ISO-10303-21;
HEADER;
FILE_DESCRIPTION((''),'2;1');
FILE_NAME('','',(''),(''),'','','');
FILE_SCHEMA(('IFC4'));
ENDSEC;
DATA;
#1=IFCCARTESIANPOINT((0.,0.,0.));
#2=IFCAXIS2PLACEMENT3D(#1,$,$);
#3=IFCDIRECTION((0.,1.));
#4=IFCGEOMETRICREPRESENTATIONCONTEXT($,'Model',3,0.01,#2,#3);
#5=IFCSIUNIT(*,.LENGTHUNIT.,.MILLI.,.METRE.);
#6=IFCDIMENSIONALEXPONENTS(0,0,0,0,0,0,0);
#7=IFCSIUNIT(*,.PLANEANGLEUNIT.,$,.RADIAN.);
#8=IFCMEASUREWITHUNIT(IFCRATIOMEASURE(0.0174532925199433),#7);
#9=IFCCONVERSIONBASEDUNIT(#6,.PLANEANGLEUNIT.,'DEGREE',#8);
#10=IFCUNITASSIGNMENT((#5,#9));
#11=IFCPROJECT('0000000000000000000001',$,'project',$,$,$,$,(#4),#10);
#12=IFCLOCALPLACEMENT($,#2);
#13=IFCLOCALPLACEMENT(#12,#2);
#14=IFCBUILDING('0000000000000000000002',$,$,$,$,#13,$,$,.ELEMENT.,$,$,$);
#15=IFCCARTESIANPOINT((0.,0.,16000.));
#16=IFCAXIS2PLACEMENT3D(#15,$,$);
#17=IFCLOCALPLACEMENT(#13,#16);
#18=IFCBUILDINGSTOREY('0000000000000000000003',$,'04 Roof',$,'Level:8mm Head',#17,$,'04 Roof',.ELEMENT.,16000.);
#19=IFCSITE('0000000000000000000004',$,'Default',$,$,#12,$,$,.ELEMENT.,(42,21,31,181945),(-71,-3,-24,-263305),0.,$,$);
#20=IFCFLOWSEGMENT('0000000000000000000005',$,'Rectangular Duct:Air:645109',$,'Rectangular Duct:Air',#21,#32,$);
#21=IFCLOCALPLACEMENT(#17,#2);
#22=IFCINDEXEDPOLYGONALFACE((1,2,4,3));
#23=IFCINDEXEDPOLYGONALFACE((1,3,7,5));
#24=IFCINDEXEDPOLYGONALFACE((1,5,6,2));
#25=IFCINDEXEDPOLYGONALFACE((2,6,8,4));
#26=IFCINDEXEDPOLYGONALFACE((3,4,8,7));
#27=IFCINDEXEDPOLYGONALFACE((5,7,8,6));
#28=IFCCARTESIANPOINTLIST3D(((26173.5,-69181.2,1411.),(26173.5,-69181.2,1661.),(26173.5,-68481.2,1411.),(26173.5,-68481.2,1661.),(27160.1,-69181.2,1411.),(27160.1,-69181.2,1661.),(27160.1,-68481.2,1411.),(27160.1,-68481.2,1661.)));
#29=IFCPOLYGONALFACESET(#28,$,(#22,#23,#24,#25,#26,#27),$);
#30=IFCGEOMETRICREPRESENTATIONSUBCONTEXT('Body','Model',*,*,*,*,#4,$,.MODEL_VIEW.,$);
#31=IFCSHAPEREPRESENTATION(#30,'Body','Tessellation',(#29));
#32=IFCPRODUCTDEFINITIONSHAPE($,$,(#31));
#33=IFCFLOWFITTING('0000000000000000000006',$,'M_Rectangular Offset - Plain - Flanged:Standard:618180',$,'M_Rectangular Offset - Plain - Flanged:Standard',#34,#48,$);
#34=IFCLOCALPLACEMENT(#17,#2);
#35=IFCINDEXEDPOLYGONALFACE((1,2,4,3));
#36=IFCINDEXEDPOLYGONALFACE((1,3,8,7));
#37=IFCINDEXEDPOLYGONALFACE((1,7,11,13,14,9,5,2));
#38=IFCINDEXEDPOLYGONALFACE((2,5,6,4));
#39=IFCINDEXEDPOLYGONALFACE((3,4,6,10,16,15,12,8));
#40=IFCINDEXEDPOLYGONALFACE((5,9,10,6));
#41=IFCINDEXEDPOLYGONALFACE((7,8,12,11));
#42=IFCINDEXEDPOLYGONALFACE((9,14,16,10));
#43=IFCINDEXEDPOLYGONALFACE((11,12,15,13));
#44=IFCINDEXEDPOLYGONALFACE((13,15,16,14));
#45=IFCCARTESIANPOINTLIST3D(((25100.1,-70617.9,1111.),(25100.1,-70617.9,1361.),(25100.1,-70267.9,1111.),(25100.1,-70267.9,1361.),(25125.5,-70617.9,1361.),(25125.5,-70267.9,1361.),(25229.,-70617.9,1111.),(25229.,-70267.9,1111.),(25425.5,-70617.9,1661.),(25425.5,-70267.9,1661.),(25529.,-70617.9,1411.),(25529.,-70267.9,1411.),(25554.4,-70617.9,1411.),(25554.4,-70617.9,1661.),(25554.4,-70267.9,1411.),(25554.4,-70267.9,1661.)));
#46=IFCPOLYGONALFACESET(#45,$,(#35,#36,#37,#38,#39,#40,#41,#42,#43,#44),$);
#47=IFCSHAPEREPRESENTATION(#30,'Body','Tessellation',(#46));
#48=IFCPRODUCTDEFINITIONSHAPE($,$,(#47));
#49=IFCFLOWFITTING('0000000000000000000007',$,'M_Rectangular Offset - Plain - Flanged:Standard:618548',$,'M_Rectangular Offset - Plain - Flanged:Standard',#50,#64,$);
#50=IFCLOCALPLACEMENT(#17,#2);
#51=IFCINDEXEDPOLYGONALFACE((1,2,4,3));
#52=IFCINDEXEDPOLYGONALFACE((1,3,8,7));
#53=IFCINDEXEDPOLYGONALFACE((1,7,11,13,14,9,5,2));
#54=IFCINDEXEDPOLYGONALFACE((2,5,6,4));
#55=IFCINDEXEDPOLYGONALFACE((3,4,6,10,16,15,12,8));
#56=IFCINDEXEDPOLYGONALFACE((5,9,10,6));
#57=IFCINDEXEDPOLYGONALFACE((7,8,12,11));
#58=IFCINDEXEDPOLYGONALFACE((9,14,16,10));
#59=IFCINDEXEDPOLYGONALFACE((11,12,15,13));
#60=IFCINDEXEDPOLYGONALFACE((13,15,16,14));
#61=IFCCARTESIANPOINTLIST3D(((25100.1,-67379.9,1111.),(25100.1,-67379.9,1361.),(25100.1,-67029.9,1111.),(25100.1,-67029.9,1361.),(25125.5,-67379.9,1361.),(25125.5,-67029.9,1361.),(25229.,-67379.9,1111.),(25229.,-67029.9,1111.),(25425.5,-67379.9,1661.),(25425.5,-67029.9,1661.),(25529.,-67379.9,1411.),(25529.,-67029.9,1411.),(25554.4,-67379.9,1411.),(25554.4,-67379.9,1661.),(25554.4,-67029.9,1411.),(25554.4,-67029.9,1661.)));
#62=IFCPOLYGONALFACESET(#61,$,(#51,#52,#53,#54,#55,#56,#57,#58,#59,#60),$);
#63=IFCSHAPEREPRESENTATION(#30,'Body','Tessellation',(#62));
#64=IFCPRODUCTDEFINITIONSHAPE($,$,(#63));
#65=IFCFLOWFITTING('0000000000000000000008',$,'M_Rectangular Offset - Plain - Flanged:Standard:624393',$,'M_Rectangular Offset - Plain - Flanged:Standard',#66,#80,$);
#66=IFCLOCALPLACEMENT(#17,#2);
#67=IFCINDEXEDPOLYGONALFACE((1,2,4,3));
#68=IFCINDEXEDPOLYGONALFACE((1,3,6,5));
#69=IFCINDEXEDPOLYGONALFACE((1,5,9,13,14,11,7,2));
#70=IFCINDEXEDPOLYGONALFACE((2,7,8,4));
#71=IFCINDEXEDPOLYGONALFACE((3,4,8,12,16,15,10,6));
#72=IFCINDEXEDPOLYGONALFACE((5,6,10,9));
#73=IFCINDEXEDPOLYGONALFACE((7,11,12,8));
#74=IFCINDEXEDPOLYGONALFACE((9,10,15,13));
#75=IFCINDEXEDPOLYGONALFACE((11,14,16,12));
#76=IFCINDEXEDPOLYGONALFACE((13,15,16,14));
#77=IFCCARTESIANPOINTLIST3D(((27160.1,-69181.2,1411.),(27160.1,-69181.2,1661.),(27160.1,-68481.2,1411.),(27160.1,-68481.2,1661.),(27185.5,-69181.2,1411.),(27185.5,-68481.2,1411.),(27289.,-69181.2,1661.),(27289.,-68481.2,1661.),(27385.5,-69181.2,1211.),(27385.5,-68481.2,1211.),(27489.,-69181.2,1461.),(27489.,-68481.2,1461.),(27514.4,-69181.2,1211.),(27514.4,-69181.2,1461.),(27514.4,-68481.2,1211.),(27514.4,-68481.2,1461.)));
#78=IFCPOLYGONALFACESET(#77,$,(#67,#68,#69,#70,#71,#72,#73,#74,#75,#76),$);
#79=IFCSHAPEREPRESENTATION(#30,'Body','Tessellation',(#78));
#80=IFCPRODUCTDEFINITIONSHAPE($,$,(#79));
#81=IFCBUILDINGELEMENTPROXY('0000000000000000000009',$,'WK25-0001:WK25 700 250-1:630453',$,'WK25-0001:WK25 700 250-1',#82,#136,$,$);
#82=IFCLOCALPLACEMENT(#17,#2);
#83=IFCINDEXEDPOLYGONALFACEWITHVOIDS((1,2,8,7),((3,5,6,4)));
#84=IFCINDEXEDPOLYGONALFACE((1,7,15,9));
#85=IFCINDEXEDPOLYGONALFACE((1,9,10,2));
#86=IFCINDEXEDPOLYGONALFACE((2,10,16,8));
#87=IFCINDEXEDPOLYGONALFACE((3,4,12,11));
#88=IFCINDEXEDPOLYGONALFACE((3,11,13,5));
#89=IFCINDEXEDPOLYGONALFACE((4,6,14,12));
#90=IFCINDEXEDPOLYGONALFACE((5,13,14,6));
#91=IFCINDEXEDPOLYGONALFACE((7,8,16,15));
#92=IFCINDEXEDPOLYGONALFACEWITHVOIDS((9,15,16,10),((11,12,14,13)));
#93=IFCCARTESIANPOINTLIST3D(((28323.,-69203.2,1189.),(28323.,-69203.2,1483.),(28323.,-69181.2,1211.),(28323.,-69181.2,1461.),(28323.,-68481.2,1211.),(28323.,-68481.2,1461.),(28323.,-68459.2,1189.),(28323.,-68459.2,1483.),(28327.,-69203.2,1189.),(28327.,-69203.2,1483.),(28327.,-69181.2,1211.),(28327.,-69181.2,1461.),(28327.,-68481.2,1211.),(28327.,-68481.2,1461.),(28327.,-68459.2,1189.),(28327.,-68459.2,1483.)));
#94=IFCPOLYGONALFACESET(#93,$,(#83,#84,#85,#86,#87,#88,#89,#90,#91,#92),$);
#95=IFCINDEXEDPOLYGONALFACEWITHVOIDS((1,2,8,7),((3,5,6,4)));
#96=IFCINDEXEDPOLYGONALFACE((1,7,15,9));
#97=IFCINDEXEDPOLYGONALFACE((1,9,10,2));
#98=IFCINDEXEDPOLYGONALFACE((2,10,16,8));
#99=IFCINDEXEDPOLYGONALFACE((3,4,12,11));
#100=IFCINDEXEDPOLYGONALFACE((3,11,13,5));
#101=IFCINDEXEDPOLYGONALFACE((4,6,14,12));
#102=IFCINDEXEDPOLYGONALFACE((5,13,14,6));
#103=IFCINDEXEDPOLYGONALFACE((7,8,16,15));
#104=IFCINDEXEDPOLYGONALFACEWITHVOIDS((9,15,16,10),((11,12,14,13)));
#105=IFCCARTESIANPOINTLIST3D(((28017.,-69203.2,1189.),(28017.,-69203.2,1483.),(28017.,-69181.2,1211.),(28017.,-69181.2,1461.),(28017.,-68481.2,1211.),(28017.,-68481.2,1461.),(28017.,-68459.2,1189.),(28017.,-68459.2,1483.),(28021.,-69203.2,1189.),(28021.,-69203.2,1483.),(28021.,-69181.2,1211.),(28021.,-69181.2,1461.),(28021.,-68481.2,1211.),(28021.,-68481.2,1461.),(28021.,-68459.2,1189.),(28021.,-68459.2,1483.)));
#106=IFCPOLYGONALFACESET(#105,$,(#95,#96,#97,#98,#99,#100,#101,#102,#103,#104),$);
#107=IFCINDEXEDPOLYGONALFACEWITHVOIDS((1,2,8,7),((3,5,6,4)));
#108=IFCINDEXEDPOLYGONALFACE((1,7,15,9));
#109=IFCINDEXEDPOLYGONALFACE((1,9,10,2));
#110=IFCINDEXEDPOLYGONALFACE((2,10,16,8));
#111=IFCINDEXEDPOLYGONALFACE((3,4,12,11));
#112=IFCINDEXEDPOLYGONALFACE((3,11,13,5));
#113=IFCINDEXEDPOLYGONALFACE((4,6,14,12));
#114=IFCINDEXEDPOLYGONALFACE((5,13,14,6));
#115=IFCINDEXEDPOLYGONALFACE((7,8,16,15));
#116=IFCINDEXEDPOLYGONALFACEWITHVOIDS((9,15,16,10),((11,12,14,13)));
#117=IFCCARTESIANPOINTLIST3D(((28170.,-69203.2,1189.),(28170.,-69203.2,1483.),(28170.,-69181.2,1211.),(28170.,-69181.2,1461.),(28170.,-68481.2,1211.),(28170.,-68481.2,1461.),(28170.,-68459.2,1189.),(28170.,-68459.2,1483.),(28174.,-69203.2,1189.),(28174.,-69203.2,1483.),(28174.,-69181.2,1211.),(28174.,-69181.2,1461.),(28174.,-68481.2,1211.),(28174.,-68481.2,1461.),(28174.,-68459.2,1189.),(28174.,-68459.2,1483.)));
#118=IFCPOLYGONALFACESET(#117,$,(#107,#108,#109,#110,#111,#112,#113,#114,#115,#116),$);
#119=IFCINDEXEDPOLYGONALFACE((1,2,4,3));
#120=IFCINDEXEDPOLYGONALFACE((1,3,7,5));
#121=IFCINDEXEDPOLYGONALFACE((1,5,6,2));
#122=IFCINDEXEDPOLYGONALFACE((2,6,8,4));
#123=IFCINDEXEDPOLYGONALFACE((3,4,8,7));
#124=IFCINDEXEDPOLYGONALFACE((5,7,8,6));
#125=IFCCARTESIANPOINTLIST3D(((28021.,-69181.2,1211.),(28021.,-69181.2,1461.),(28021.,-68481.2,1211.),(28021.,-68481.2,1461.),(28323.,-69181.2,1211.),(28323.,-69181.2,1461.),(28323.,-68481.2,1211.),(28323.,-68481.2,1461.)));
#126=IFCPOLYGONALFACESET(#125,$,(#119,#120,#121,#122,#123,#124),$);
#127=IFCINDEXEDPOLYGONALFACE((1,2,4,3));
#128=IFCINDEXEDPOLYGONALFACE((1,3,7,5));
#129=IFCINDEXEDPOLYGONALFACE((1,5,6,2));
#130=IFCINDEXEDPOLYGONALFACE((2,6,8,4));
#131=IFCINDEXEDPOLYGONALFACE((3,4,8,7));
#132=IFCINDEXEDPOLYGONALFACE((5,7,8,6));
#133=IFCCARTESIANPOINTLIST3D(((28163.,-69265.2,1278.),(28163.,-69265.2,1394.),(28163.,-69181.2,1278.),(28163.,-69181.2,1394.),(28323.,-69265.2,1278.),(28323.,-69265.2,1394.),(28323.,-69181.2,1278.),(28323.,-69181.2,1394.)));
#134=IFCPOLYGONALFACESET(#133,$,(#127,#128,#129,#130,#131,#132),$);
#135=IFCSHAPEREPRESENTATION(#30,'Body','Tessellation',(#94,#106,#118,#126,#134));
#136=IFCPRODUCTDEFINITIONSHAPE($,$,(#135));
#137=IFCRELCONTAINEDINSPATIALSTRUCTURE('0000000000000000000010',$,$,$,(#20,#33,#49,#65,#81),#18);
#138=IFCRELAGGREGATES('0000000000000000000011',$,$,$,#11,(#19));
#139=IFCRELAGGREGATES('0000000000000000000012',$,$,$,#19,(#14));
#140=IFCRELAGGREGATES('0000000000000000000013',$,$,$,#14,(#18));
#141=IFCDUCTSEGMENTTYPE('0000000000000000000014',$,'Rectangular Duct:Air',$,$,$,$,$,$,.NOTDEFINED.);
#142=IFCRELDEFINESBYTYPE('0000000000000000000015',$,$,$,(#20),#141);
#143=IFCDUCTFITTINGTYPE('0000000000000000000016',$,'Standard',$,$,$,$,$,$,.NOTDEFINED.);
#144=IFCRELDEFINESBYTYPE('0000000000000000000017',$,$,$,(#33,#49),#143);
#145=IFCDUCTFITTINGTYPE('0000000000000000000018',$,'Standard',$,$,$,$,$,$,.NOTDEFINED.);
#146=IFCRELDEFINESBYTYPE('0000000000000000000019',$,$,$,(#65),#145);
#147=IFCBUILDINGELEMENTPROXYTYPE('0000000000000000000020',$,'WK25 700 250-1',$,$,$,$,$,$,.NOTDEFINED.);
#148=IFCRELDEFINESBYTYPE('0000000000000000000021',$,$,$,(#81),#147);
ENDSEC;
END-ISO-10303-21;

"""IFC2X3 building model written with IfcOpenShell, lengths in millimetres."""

from ifc_helpers import new_model, entity, si_unit, converted_unit, direction, frame, frame_2d, origin, origin_2d_with_axis, place, context, subcontext, project, spatial, polyline, rectangle, outline, extrude, source, transform, mapped, type_object, type_shapes, element, save


model = new_model("IFC2X3")

# Units and contexts
model_context = context("Model", 3, precision=0.01, world=origin(), true_north=direction((0.0, 1.0)))
body_context = subcontext(model_context, "Body", "Model", "MODEL_VIEW")
ifc_project = project(units=[si_unit("LENGTHUNIT", "METRE", prefix="MILLI"), converted_unit("PLANEANGLEUNIT", "DEGREE", entity("IfcRatioMeasure", 0.0174532925199433), si_unit("PLANEANGLEUNIT", "RADIAN"), dimensions=[0, 0, 0, 0, 0, 0, 0])], contexts=[model_context])

# Site, building, storey
site_placement = place(None, origin())
site = spatial("IfcSite", under=ifc_project, at=site_placement, Name="Default", CompositionType="ELEMENT", RefLatitude=(42, 21, 31, 181945), RefLongitude=(-71, -3, -24, -263305), RefElevation=0.0)
building_placement = place(site_placement, origin())
building = spatial("IfcBuilding", under=site, at=building_placement, CompositionType="ELEMENT")
storey_placement = place(building_placement, frame((0.0, 0.0, 16000.0)))
storey = spatial("IfcBuildingStorey", under=building, at=storey_placement, Name="04 Roof", ObjectType="Level:8mm Head", LongName="04 Roof", CompositionType="ELEMENT", Elevation=16000.0)

# Flow segment
duct_segment_type = type_object("IfcDuctSegmentType", Name="Rectangular Duct:Air", PredefinedType="NOTDEFINED")
flow_segment_1_placement = place(storey_placement, frame((26173.5, -69181.2, 1411.0)))
element("IfcFlowSegment", 1, at=flow_segment_1_placement, inside=storey, type_object=duct_segment_type, Name="Rectangular Duct:Air:645109", ObjectType="Rectangular Duct:Air", context=body_context, shape_type="SweptSolid", body=[
    extrude(rectangle(XDim=986.6, YDim=700.0, at=frame_2d((0.0, 0.0), x_axis=(1.0, 0.0))), frame((493.3, 350.0, 0.0), z_axis=(0.0, 0.0, 1.0), x_axis=(-1.0, 0.0, 0.0)), (0.0, 0.0, 1.0), 250.0),
])

# Flow fittings
duct_fitting_type_1 = type_object("IfcDuctFittingType", Name="Standard", PredefinedType="NOTDEFINED")
shared_shape_1 = source(origin(), body_context, "Body", "SweptSolid", [
    extrude(outline(polyline([(-227.2, -275.0), (-98.2, -275.0), (201.8, 25.0), (227.2, 25.0), (227.2, 275.0), (98.2, 275.0), (-201.8, -25.0), (-227.2, -25.0), (-227.2, -275.0)])), frame((227.2, 150.0, -175.0)), (0.0, 0.0, 1.0), 350.0),
])
type_shapes(duct_fitting_type_1, [shared_shape_1])
for number, where, z_axis, x_axis, name in (
    (2, (25100.1, -70442.9, 1236.0), (0.0, -1.0, 0.0), (1.0, 0.0, 0.0), "M_Rectangular Offset - Plain - Flanged:Standard:618180"),
    (3, (25100.1, -67204.9, 1236.0), (0.0, -1.0, 0.0), (1.0, 0.0, 0.0), "M_Rectangular Offset - Plain - Flanged:Standard:618548"),
):
    element("IfcFlowFitting", number, at=place(storey_placement, frame(where, z_axis=z_axis, x_axis=x_axis)), inside=storey, type_object=duct_fitting_type_1, Name=name, ObjectType="M_Rectangular Offset - Plain - Flanged:Standard", context=body_context, shape_type="MappedRepresentation", body=[
        mapped(shared_shape_1, transform((0.0, 0.0, 0.0), scale=1.0)),
    ])
duct_fitting_type_2 = type_object("IfcDuctFittingType", Name="Standard", PredefinedType="NOTDEFINED")
shared_shape_2 = source(origin(), body_context, "Body", "SweptSolid", [
    extrude(outline(polyline([(-177.2, -225.0), (-48.2, -225.0), (151.8, -25.0), (177.2, -25.0), (177.2, 225.0), (48.2, 225.0), (-151.8, 25.0), (-177.2, 25.0), (-177.2, -225.0)])), frame((177.2, 100.0, -350.0)), (0.0, 0.0, 1.0), 700.0),
])
type_shapes(duct_fitting_type_2, [shared_shape_2])
flow_fitting_1_placement = place(storey_placement, frame((27160.1, -68831.2, 1536.0), z_axis=(0.0, 1.0, 0.0), x_axis=(1.0, 0.0, 0.0)))
element("IfcFlowFitting", 4, at=flow_fitting_1_placement, inside=storey, type_object=duct_fitting_type_2, Name="M_Rectangular Offset - Plain - Flanged:Standard:624393", ObjectType="M_Rectangular Offset - Plain - Flanged:Standard", context=body_context, shape_type="MappedRepresentation", body=[
    mapped(shared_shape_2, transform((0.0, 0.0, 0.0), scale=1.0)),
])

# Building element proxy
building_element_proxy_type = type_object("IfcBuildingElementProxyType", Name="WK25 700 250-1", PredefinedType="NOTDEFINED")
shared_shape_3 = source(origin(), body_context, "Body", "SweptSolid", [
    extrude(outline(polyline([(-147.0, -372.0), (147.0, -372.0), (147.0, 372.0), (-147.0, 372.0), (-147.0, -372.0)]), holes=[polyline([(-125.0, -350.0), (-125.0, 350.0), (125.0, 350.0), (125.0, -350.0), (-125.0, -350.0)])]), frame((151.0, 0.0, 0.0), z_axis=(1.0, 0.0, 0.0), x_axis=(0.0, 0.0, -1.0)), (0.0, 0.0, 1.0), 4.0),
    extrude(outline(polyline([(-372.0, -147.0), (372.0, -147.0), (372.0, 147.0), (-372.0, 147.0), (-372.0, -147.0)]), holes=[polyline([(-350.0, -125.0), (-350.0, 125.0), (350.0, 125.0), (350.0, -125.0), (-350.0, -125.0)])]), frame((-155.0, 0.0, 0.0), z_axis=(1.0, 0.0, 0.0), x_axis=(0.0, -1.0, 0.0)), (0.0, 0.0, 1.0), 4.0),
    extrude(outline(polyline([(-372.0, -147.0), (372.0, -147.0), (372.0, 147.0), (-372.0, 147.0), (-372.0, -147.0)]), holes=[polyline([(-350.0, -125.0), (-350.0, 125.0), (350.0, 125.0), (350.0, -125.0), (-350.0, -125.0)])]), frame((-2.0, 0.0, 0.0), z_axis=(1.0, 0.0, 0.0), x_axis=(0.0, -1.0, 0.0)), (0.0, 0.0, 1.0), 4.0),
    extrude(rectangle(XDim=302.0, YDim=700.0, at=origin_2d_with_axis()), frame((0.0, 0.0, -125.0), z_axis=(0.0, 0.0, 1.0), x_axis=(-1.0, 0.0, 0.0)), (0.0, 0.0, 1.0), 250.0),
    extrude(rectangle(XDim=84.0, YDim=160.0, at=origin_2d_with_axis()), frame((71.0, -392.0, -58.0), z_axis=(0.0, 0.0, 1.0), x_axis=(0.0, -1.0, 0.0)), (0.0, 0.0, 1.0), 116.0),
])
type_shapes(building_element_proxy_type, [shared_shape_3])
proxy_placement = place(storey_placement, frame((28172.0, -68831.2, 1336.0)))
element("IfcBuildingElementProxy", 5, at=proxy_placement, inside=storey, type_object=building_element_proxy_type, Name="WK25-0001:WK25 700 250-1:630453", ObjectType="WK25-0001:WK25 700 250-1", context=body_context, shape_type="MappedRepresentation", body=[
    mapped(shared_shape_3, transform((0.0, 0.0, 0.0), scale=1.0)),
])

save(model, "model.ifc")
